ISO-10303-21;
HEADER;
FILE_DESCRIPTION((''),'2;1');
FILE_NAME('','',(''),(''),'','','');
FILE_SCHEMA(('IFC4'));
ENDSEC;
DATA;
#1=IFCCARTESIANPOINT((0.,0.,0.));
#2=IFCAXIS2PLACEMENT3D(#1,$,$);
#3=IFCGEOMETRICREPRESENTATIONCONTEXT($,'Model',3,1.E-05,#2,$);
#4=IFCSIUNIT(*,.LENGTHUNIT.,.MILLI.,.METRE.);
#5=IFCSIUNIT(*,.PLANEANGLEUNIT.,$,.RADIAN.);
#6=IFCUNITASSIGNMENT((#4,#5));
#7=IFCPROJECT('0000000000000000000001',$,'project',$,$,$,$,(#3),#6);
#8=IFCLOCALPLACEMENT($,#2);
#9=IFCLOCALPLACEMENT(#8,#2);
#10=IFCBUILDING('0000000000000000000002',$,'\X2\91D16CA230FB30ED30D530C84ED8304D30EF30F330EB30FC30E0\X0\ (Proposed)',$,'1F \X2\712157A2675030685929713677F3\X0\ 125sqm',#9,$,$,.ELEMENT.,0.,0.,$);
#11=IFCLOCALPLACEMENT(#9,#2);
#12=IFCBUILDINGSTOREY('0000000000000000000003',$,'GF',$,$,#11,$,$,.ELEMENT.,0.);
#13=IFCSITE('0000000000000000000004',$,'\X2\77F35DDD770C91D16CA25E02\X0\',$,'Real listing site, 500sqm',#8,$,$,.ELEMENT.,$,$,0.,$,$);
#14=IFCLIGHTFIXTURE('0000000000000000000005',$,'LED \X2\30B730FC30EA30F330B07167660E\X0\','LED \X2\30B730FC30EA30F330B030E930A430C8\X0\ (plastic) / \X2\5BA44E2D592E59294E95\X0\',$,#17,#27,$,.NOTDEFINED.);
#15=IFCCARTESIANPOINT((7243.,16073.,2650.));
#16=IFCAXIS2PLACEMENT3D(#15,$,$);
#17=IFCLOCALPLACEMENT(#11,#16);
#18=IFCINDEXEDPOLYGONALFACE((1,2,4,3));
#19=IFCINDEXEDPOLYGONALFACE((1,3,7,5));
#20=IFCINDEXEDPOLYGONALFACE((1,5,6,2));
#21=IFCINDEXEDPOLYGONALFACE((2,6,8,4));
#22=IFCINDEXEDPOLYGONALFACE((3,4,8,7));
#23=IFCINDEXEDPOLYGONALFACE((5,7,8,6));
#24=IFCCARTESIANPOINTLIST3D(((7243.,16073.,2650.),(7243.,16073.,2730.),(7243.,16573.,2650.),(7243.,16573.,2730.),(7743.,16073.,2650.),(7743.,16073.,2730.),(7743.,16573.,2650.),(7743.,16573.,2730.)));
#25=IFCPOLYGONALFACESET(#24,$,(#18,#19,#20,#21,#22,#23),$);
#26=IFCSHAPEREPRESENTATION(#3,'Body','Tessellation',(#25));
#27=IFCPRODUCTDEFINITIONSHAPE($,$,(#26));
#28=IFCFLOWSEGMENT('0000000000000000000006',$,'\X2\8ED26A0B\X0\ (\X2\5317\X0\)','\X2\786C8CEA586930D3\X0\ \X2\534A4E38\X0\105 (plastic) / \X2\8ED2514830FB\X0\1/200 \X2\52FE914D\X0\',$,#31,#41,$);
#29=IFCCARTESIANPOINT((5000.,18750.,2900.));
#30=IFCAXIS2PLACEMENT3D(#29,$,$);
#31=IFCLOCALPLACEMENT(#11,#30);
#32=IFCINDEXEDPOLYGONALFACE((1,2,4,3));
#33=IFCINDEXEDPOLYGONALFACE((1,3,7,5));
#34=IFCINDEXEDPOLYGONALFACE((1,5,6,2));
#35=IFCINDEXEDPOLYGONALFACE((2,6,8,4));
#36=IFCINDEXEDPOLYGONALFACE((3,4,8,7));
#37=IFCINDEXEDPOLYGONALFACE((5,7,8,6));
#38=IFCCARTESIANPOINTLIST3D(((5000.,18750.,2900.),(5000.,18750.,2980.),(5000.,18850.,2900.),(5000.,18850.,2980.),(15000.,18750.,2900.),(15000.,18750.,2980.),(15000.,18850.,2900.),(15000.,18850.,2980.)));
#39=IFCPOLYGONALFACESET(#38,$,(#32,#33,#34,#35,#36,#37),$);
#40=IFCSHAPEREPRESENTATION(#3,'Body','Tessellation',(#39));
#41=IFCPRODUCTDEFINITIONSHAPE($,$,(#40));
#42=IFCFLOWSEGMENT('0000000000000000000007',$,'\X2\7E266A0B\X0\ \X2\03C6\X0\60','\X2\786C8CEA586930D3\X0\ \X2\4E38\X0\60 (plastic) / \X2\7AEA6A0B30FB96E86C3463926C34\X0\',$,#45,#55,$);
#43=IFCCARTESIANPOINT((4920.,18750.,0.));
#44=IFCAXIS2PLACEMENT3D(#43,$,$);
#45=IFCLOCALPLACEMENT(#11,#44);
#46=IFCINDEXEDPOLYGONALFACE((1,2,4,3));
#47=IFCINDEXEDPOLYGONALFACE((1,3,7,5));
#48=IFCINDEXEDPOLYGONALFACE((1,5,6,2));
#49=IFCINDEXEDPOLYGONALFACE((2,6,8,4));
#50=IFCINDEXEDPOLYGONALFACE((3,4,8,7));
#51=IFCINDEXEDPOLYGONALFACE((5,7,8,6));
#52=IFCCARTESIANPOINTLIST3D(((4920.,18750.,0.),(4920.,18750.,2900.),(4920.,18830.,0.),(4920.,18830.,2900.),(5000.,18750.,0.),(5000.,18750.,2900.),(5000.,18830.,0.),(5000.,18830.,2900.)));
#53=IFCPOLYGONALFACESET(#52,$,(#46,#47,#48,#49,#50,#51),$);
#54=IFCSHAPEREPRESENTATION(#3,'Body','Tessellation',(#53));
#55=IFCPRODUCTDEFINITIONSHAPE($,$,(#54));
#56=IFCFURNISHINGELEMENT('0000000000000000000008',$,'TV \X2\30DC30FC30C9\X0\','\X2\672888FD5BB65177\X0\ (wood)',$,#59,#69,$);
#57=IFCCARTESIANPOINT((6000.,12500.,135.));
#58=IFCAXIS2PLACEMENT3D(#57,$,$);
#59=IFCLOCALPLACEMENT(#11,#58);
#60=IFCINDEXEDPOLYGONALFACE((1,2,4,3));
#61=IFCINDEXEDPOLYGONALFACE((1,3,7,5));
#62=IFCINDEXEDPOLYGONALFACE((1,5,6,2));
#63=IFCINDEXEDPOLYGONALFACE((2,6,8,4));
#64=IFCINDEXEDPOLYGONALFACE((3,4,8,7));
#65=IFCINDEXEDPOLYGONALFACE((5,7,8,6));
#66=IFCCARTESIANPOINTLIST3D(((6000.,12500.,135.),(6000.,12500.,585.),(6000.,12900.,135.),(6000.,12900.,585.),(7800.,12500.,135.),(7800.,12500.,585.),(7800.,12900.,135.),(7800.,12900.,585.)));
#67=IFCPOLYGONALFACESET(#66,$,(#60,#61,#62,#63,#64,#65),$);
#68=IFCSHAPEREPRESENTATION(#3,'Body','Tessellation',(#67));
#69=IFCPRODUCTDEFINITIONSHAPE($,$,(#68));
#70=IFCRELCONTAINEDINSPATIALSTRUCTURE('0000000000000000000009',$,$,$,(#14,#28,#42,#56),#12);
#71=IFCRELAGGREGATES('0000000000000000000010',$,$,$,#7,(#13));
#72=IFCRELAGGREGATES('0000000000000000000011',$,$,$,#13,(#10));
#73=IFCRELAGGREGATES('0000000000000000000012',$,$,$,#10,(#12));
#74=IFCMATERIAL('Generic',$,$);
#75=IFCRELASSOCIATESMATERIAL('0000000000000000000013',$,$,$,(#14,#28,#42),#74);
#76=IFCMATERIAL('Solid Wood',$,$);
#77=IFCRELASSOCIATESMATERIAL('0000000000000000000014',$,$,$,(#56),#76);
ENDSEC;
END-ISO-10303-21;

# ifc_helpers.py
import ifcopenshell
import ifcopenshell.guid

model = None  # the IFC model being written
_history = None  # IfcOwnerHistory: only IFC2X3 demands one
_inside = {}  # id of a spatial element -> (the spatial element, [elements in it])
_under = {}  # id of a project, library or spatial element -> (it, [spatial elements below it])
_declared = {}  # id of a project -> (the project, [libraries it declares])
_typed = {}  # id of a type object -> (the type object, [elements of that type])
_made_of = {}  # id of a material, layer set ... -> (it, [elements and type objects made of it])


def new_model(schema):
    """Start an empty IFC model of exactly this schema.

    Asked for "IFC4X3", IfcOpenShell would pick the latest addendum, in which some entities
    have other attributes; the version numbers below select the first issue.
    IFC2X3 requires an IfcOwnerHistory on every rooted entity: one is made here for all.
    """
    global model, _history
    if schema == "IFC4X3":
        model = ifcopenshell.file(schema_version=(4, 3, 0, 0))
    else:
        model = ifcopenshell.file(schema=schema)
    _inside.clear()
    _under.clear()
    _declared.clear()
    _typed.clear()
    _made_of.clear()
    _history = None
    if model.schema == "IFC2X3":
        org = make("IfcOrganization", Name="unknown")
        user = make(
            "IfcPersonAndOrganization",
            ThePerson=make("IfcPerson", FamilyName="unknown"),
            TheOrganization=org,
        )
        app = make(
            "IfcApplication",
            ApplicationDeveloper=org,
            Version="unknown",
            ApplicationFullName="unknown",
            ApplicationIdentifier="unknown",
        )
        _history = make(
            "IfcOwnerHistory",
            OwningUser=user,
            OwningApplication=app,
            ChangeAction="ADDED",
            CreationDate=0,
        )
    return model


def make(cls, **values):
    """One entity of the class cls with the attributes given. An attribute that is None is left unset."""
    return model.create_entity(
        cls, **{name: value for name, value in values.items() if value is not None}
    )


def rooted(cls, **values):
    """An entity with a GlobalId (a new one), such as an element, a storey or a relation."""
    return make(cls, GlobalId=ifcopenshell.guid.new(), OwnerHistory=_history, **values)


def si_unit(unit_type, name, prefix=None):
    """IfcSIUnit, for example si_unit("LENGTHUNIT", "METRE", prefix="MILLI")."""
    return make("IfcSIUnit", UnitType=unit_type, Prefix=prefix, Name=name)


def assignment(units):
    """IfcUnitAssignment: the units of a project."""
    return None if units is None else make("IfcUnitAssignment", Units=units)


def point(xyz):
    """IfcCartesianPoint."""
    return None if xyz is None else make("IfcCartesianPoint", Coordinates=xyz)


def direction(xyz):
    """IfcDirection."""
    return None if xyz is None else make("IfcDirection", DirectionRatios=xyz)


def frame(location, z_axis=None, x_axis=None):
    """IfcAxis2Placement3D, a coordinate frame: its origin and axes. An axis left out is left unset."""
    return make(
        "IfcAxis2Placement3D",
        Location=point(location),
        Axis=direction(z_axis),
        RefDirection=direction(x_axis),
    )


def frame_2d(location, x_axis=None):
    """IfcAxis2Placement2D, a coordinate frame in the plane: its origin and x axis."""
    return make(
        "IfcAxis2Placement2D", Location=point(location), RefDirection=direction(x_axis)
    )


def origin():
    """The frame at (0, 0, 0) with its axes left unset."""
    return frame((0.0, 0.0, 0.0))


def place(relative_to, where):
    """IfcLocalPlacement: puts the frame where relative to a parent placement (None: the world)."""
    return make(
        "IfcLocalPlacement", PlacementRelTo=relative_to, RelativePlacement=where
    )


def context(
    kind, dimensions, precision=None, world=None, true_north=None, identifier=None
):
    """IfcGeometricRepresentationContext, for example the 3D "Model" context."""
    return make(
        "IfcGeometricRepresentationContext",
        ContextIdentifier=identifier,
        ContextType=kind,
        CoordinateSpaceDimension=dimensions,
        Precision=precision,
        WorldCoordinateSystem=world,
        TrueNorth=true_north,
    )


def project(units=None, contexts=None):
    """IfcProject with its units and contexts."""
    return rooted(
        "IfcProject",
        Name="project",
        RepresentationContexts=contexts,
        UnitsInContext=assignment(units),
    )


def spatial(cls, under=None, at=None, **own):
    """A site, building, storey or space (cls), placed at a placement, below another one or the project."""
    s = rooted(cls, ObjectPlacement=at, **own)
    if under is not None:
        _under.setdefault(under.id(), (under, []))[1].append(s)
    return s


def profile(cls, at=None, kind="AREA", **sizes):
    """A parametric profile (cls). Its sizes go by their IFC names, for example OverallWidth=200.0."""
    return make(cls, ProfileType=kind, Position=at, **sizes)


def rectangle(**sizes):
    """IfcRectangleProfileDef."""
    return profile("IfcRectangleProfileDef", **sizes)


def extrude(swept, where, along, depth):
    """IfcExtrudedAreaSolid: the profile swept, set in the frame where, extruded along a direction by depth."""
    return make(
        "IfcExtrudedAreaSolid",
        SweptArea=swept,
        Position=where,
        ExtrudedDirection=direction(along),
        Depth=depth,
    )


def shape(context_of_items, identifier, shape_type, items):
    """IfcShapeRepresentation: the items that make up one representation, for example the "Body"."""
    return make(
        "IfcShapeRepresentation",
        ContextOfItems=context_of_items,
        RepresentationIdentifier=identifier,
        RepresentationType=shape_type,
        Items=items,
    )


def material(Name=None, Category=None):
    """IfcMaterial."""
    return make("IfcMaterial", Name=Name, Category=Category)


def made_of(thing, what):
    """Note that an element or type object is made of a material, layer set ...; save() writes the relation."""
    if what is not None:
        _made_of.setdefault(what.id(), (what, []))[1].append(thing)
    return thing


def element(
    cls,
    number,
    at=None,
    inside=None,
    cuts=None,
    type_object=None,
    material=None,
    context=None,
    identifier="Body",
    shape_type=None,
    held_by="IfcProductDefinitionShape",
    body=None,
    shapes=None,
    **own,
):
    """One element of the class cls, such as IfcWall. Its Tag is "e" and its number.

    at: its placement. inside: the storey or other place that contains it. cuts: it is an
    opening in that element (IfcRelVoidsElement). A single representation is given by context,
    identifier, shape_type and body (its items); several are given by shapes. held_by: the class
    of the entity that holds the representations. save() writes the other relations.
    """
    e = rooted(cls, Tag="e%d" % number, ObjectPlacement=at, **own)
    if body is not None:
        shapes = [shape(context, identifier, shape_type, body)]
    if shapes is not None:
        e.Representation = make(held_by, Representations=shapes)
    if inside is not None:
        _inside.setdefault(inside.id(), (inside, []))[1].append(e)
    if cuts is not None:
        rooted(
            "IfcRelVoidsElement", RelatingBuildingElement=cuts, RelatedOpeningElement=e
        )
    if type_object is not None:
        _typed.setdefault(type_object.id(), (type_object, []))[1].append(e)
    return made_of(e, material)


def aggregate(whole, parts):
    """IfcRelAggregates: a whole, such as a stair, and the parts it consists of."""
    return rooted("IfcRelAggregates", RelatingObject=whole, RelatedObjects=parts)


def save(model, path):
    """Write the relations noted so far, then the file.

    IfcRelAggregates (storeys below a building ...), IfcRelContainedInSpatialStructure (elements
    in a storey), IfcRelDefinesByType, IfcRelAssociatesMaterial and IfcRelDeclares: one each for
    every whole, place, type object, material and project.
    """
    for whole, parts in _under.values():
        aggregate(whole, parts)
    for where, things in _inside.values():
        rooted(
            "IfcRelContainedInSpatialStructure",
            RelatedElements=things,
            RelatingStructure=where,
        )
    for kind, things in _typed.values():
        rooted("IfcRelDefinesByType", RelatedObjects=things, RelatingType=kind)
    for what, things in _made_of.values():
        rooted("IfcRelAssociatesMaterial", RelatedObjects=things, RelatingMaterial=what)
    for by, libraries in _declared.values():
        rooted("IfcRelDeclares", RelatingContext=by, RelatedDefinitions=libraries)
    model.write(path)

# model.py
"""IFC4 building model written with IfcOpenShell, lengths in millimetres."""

from ifc_helpers import new_model, si_unit, frame, frame_2d, origin, place, context, project, spatial, rectangle, extrude, material, element, save


model = new_model("IFC4")

# Units and contexts
model_context = context("Model", 3, precision=1e-05, world=origin())
ifc_project = project(units=[si_unit("LENGTHUNIT", "METRE", prefix="MILLI"), si_unit("PLANEANGLEUNIT", "RADIAN")], contexts=[model_context])

# Site, building, storey
site_placement = place(None, origin())
site = spatial("IfcSite", under=ifc_project, at=site_placement, Name="石川県金沢市", ObjectType="Real listing site, 500sqm", CompositionType="ELEMENT", RefElevation=0.0)
building_placement = place(site_placement, origin())
building = spatial("IfcBuilding", under=site, at=building_placement, Name="金沢・ロフト付きワンルーム (Proposed)", ObjectType="1F 無垢材と天然石 125sqm", CompositionType="ELEMENT", ElevationOfRefHeight=0.0, ElevationOfTerrain=0.0)
storey_placement = place(building_placement, origin())
storey = spatial("IfcBuildingStorey", under=building, at=storey_placement, Name="GF", CompositionType="ELEMENT", Elevation=0.0)

# Shared definitions
ifc_material_1 = material(Name="Solid Wood")

# Shared definitions
ifc_material_2 = material(Name="Generic")

# Light fixture
light_fixture_placement = place(storey_placement, frame((7243.0, 16073.0, 2650.0)))
element("IfcLightFixture", 1, at=light_fixture_placement, inside=storey, material=ifc_material_2, Name="LED シーリング照明", Description="LED シーリングライト (plastic) / 室中央天井", PredefinedType="NOTDEFINED", context=model_context, shape_type="SweptSolid", body=[
    extrude(rectangle(XDim=500.0, YDim=500.0, at=frame_2d((250.0, 250.0))), frame((7243.0, 16073.0, 2650.0)), (0.0, 0.0, 1.0), 80.0),
])

# Flow segments
flow_segment_1_placement = place(storey_placement, frame((5000.0, 18750.0, 2900.0)))
element("IfcFlowSegment", 2, at=flow_segment_1_placement, inside=storey, material=ifc_material_2, Name="軒樋 (北)", Description="硬質塩ビ 半丸105 (plastic) / 軒先・1/200 勾配", context=model_context, shape_type="SweptSolid", body=[
    extrude(rectangle(XDim=10000.0, YDim=100.0, at=frame_2d((5000.0, 50.0))), frame((5000.0, 18750.0, 2900.0)), (0.0, 0.0, 1.0), 80.0),
])
flow_segment_2_placement = place(storey_placement, frame((4920.0, 18750.0, 0.0)))
element("IfcFlowSegment", 3, at=flow_segment_2_placement, inside=storey, material=ifc_material_2, Name="縦樋 φ60", Description="硬質塩ビ 丸60 (plastic) / 竪樋・雨水排水", context=model_context, shape_type="SweptSolid", body=[
    extrude(rectangle(XDim=80.0, YDim=80.0, at=frame_2d((40.0, 40.0))), frame((4920.0, 18750.0, 0.0)), (0.0, 0.0, 1.0), 2900.0),
])

# Furnishing element
furnishing_placement = place(storey_placement, frame((6000.0, 12500.0, 135.0)))
element("IfcFurnishingElement", 4, at=furnishing_placement, inside=storey, material=ifc_material_1, Name="TV ボード", Description="木製家具 (wood)", context=model_context, shape_type="SweptSolid", body=[
    extrude(rectangle(XDim=1800.0, YDim=400.0, at=frame_2d((900.0, 200.0))), frame((6000.0, 12500.0, 135.0)), (0.0, 0.0, 1.0), 450.0),
])

save(model, "model.ifc")
